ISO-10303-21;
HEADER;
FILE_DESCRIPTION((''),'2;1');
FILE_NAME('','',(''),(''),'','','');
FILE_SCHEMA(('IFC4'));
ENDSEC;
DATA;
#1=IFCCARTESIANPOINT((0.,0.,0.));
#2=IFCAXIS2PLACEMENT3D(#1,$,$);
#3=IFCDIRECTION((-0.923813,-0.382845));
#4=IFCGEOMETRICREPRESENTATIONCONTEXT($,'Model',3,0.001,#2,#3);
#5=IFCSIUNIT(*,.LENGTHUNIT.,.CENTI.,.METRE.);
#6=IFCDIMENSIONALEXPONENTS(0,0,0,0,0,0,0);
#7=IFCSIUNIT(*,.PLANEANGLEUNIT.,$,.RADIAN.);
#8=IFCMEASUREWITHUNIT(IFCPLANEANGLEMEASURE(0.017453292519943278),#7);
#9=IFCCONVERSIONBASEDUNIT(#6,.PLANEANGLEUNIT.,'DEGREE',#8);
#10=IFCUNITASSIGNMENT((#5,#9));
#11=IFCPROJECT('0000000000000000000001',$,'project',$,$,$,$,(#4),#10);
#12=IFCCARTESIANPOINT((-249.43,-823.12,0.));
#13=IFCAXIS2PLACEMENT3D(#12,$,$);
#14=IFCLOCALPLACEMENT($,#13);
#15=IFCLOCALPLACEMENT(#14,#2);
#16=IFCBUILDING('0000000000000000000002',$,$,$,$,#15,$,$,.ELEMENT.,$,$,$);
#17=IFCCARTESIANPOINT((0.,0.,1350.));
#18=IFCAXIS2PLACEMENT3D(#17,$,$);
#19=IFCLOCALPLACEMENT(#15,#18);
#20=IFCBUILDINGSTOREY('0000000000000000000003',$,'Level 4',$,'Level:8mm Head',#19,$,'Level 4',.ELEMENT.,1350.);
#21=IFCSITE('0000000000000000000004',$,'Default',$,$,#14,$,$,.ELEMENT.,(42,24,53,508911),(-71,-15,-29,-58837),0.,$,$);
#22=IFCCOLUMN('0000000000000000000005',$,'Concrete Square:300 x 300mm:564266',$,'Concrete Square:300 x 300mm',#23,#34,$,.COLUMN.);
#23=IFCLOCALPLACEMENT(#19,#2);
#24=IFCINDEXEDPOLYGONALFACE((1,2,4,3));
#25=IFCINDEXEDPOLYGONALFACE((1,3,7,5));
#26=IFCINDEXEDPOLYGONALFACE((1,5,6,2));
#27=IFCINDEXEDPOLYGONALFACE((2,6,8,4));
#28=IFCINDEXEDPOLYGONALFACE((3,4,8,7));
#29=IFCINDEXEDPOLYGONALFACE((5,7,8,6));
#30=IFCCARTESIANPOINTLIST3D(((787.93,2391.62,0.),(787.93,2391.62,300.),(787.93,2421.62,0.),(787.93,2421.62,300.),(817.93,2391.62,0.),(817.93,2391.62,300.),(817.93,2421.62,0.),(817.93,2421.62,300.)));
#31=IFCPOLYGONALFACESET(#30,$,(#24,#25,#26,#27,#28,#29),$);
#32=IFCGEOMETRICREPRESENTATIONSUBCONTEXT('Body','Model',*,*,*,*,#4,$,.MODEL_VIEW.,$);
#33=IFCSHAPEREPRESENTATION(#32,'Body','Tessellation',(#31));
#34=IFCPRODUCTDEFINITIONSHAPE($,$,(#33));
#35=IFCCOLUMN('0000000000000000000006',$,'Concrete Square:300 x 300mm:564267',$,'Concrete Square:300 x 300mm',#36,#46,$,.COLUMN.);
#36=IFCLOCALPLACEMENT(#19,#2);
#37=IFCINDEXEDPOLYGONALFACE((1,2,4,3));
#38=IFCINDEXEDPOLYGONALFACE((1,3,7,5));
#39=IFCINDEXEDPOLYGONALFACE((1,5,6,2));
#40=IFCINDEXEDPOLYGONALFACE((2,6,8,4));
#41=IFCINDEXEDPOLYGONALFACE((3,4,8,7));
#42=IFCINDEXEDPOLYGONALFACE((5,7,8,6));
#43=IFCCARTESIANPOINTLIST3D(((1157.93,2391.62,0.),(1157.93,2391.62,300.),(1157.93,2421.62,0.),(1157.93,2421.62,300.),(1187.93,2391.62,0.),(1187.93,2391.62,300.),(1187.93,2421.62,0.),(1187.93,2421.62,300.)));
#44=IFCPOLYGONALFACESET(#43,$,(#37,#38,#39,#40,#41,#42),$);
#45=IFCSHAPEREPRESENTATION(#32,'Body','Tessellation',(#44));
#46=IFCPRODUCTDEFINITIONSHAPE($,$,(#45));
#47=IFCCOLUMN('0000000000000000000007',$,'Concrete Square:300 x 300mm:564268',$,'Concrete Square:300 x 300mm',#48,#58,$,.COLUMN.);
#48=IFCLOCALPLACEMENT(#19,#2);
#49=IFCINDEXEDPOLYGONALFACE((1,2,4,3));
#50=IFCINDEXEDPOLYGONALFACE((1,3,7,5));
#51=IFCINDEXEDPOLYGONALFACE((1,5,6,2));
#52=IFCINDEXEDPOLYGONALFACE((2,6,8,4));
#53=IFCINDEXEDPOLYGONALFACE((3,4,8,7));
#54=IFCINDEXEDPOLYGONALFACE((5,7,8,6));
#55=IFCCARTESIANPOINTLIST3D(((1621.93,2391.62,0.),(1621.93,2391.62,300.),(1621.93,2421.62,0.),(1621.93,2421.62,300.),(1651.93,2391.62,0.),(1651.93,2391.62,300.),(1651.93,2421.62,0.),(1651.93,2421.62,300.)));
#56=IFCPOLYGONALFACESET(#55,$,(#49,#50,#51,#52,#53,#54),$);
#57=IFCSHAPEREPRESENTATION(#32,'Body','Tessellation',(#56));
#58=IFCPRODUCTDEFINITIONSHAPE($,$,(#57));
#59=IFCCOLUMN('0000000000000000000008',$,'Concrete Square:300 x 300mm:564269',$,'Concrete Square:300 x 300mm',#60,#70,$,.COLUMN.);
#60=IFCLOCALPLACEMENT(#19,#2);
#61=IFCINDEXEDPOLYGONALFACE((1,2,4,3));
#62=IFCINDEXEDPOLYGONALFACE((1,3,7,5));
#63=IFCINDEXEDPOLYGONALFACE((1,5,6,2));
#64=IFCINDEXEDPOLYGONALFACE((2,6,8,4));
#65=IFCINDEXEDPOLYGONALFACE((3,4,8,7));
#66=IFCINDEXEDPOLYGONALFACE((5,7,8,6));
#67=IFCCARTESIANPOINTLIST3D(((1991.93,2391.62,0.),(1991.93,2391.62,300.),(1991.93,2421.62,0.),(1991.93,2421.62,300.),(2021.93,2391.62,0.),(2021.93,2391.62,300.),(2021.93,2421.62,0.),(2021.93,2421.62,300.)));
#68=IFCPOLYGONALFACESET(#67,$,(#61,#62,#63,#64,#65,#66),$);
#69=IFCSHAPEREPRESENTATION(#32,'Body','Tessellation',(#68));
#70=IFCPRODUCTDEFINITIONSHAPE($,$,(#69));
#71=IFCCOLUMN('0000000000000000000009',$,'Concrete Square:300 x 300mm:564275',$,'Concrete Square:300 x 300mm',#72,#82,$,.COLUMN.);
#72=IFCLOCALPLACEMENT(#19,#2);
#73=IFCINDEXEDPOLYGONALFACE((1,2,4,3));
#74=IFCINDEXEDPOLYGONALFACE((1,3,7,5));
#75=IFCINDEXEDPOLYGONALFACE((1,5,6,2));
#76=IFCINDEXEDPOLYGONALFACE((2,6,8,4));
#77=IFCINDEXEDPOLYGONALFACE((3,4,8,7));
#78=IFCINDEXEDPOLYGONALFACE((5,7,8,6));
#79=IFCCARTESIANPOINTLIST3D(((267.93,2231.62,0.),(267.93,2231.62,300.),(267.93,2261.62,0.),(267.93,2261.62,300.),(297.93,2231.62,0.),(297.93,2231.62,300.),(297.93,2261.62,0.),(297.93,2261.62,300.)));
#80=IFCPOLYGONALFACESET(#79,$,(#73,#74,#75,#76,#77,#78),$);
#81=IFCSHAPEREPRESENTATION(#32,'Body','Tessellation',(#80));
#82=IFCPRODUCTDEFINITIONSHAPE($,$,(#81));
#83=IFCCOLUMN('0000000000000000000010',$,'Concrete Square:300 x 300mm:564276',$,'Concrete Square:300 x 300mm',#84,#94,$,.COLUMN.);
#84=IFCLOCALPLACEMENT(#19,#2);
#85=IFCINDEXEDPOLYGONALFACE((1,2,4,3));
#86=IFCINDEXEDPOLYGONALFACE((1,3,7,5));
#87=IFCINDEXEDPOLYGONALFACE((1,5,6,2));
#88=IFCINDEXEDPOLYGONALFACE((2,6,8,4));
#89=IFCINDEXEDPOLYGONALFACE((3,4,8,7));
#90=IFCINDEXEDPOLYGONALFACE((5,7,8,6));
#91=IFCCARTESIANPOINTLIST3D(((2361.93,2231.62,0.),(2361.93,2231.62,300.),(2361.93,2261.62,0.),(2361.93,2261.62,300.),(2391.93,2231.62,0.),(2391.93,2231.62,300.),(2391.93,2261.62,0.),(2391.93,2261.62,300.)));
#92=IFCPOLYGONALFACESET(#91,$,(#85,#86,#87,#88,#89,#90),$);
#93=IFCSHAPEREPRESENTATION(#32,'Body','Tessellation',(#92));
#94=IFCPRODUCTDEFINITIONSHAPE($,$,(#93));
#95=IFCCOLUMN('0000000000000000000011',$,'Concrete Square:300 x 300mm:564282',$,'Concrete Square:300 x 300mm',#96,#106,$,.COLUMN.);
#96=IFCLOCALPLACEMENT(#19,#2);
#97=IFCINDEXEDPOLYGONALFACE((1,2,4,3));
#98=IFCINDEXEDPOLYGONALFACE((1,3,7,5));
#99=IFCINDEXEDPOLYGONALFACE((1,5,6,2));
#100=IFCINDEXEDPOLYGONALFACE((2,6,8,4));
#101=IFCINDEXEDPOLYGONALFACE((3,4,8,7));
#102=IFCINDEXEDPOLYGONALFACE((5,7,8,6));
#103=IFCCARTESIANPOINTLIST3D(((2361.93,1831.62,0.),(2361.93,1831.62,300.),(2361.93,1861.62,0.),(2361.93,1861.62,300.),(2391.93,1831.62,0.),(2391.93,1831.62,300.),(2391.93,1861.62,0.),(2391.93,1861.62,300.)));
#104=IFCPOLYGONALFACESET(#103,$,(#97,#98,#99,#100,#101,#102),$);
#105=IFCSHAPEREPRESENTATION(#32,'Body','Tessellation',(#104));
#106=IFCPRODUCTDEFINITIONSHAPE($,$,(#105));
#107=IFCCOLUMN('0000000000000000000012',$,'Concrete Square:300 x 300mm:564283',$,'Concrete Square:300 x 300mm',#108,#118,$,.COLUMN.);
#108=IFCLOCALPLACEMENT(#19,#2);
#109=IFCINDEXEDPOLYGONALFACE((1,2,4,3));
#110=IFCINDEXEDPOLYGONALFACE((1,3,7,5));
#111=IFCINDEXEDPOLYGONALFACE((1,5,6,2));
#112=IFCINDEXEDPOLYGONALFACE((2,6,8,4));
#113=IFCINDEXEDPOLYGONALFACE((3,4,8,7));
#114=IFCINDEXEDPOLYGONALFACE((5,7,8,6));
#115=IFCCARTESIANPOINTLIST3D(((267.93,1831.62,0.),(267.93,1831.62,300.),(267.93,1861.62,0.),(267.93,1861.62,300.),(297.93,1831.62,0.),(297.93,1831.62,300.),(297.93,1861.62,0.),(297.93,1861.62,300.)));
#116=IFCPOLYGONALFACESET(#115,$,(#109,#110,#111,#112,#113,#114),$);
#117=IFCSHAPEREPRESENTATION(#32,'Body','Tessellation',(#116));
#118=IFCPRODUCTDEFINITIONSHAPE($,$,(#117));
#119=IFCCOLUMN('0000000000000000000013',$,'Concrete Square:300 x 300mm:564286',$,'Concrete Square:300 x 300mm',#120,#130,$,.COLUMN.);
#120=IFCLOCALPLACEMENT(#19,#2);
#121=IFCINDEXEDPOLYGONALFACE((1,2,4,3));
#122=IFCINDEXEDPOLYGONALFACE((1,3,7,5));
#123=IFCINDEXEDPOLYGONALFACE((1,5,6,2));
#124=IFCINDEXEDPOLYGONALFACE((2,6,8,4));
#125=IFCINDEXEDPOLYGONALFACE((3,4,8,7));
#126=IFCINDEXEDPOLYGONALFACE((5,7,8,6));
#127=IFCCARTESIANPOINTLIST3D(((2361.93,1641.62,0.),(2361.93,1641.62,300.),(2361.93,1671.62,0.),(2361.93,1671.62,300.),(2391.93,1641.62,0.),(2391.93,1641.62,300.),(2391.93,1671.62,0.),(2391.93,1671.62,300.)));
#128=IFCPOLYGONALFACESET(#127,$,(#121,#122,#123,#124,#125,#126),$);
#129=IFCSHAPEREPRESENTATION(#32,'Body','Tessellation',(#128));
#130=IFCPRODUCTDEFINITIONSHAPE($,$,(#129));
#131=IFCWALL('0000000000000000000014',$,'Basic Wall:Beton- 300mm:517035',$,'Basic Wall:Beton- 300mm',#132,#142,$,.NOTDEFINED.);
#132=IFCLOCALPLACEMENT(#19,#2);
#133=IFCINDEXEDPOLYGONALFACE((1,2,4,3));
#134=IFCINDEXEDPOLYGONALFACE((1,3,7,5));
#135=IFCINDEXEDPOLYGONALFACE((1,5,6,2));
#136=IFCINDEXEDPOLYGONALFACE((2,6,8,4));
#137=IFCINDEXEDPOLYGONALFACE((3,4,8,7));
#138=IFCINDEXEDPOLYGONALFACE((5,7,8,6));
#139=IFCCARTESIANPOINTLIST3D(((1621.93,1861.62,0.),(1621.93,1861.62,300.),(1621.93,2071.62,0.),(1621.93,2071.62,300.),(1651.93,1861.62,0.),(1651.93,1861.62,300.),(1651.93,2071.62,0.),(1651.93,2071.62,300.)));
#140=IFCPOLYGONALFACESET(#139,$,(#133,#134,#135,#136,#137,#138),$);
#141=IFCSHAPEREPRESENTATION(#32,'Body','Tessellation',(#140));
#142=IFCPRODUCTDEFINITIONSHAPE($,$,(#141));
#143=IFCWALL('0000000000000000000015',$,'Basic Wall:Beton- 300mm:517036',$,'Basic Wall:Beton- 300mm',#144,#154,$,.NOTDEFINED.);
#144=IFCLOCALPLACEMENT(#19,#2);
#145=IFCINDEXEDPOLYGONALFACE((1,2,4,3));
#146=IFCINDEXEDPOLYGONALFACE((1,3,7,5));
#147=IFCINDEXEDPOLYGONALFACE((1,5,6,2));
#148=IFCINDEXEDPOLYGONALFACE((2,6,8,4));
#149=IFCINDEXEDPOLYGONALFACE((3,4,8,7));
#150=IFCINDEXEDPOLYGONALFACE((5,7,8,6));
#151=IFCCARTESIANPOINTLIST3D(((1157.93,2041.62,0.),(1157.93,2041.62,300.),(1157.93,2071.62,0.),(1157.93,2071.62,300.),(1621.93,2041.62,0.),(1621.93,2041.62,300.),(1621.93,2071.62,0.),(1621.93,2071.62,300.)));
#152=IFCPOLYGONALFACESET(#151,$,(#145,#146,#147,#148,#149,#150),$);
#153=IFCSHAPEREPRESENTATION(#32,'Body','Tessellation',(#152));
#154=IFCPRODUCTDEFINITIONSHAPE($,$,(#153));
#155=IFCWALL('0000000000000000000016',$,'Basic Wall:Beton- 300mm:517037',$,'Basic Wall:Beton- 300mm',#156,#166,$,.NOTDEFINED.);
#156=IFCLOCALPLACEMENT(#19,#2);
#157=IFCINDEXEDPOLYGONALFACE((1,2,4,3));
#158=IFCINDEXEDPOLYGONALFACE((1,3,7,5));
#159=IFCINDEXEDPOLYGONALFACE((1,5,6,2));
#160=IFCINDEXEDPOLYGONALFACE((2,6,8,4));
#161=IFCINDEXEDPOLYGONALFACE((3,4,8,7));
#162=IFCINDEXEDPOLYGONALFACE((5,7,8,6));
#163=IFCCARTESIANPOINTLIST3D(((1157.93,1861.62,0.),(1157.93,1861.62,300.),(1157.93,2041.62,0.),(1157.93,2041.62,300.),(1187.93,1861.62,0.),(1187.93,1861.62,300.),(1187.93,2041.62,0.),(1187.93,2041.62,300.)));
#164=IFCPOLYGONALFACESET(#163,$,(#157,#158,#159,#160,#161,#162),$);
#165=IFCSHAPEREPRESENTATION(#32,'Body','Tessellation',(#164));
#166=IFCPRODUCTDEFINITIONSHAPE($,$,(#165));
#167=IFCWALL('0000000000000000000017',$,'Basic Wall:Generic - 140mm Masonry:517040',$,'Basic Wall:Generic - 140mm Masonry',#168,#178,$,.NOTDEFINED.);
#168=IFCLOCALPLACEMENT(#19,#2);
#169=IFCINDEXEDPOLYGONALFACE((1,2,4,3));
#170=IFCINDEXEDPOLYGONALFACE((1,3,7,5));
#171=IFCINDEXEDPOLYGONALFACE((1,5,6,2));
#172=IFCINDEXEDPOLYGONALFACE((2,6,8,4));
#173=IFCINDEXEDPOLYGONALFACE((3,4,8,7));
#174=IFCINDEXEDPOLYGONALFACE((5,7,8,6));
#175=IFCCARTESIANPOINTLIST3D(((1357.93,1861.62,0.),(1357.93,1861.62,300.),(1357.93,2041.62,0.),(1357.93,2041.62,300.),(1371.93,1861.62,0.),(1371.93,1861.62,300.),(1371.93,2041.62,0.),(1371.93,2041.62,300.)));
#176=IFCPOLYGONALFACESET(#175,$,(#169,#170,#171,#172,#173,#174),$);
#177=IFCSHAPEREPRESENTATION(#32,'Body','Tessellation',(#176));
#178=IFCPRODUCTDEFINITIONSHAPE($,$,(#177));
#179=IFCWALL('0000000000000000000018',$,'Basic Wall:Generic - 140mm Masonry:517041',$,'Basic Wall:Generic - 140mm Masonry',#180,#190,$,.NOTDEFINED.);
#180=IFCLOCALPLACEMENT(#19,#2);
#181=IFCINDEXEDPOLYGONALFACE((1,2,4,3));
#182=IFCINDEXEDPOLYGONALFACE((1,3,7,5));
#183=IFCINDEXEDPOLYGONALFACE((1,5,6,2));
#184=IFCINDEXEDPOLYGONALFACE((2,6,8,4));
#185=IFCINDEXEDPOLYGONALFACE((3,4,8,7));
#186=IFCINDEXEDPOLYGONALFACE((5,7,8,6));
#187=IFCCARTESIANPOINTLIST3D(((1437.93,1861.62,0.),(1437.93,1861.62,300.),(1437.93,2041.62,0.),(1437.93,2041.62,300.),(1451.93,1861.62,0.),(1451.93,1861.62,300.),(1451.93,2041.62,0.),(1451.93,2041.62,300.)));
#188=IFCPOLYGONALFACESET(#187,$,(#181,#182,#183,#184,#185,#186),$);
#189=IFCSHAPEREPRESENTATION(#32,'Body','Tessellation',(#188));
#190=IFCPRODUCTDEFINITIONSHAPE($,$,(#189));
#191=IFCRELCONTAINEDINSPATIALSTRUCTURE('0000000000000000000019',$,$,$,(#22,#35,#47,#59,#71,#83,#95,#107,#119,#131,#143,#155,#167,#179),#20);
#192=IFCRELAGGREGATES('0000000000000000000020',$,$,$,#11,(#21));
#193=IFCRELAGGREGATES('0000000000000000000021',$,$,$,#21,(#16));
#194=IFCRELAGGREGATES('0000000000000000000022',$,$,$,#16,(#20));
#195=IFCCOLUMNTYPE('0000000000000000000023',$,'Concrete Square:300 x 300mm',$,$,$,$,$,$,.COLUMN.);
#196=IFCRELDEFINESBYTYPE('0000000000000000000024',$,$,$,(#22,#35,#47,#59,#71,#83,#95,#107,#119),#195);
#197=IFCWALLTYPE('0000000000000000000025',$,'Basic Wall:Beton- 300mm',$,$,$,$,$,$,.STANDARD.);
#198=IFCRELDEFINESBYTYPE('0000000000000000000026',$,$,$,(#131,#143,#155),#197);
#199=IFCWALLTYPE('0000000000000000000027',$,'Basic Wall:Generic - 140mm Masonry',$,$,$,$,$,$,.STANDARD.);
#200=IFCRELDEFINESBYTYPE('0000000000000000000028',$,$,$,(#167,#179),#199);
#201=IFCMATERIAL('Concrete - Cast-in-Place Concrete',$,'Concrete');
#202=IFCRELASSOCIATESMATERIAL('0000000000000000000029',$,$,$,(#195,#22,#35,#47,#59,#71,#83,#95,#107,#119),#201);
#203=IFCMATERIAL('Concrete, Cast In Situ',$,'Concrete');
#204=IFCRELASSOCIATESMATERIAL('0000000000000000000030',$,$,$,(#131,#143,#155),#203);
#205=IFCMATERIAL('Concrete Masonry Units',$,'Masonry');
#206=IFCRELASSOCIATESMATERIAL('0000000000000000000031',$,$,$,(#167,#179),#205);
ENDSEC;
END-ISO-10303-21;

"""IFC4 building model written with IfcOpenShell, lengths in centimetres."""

from ifc_helpers import new_model, entity, si_unit, converted_unit, direction, frame, origin, place, context, subcontext, project, spatial, indexed_curve, outline, extrude, source, transform, mapped, material, type_object, type_shapes, element, save


model = new_model("IFC4")

# Units and contexts
model_context = context("Model", 3, precision=0.001, world=origin(), true_north=direction((-0.923813, -0.382845)))
body_context = subcontext(model_context, "Body", "Model", "MODEL_VIEW")
ifc_project = project(units=[si_unit("LENGTHUNIT", "METRE", prefix="CENTI"), converted_unit("PLANEANGLEUNIT", "DEGREE", entity("IfcPlaneAngleMeasure", 0.017453292519943278), si_unit("PLANEANGLEUNIT", "RADIAN"), dimensions=[0, 0, 0, 0, 0, 0, 0])], contexts=[model_context])

# Site, building, storey
site_placement = place(None, frame((-249.43, -823.12, 0.0)))
site = spatial("IfcSite", under=ifc_project, at=site_placement, Name="Default", CompositionType="ELEMENT", RefLatitude=(42, 24, 53, 508911), RefLongitude=(-71, -15, -29, -58837), RefElevation=0.0)
building_placement = place(site_placement, origin())
building = spatial("IfcBuilding", under=site, at=building_placement, CompositionType="ELEMENT")
storey_placement = place(building_placement, frame((0.0, 0.0, 1350.0)))
storey = spatial("IfcBuildingStorey", under=building, at=storey_placement, Name="Level 4", ObjectType="Level:8mm Head", LongName="Level 4", CompositionType="ELEMENT", Elevation=1350.0)

# Columns
ifc_material_1 = material(Name="Concrete - Cast-in-Place Concrete", Category="Concrete")
column_type = type_object("IfcColumnType", Name="Concrete Square:300 x 300mm", PredefinedType="COLUMN", material=ifc_material_1)
shared_shape_1 = source(origin(), body_context, "Body", "SweptSolid", [
    extrude(outline(indexed_curve([(-15.0, -15.0), (15.0, -15.0), (15.0, 15.0), (-15.0, 15.0), (-15.0, -15.0)], self_intersect=False)), frame((0.0, 0.0, 1350.0), z_axis=(0.0, 0.0, 1.0), x_axis=(-1.0, 0.0, 0.0)), (0.0, 0.0, 1.0), 300.0),
])
type_shapes(column_type, [shared_shape_1])
for number, where, name in (
    (1, (802.93, 2406.62, -1350.0), "Concrete Square:300 x 300mm:564266"),
    (2, (1172.93, 2406.62, -1350.0), "Concrete Square:300 x 300mm:564267"),
    (3, (1636.93, 2406.62, -1350.0), "Concrete Square:300 x 300mm:564268"),
    (4, (2006.93, 2406.62, -1350.0), "Concrete Square:300 x 300mm:564269"),
    (5, (282.93, 2246.62, -1350.0), "Concrete Square:300 x 300mm:564275"),
    (6, (2376.93, 2246.62, -1350.0), "Concrete Square:300 x 300mm:564276"),
    (7, (2376.93, 1846.62, -1350.0), "Concrete Square:300 x 300mm:564282"),
    (8, (282.93, 1846.62, -1350.0), "Concrete Square:300 x 300mm:564283"),
    (9, (2376.93, 1656.62, -1350.0), "Concrete Square:300 x 300mm:564286"),
):
    element("IfcColumn", number, at=place(storey_placement, frame(where)), inside=storey, type_object=column_type, material=ifc_material_1, Name=name, ObjectType="Concrete Square:300 x 300mm", PredefinedType="COLUMN", context=body_context, shape_type="MappedRepresentation", body=[
        mapped(shared_shape_1, transform((0.0, 0.0, 0.0), scale=1.0)),
    ])

# Walls
ifc_material_2 = material(Name="Concrete, Cast In Situ", Category="Concrete")
wall_type_1 = type_object("IfcWallType", Name="Basic Wall:Beton- 300mm", PredefinedType="STANDARD")
wall_1_placement = place(storey_placement, frame((1636.93, 1861.62, 0.0), z_axis=(0.0, 0.0, 1.0), x_axis=(0.0, 1.0, 0.0)))
element("IfcWall", 10, at=wall_1_placement, inside=storey, type_object=wall_type_1, material=ifc_material_2, Name="Basic Wall:Beton- 300mm:517035", ObjectType="Basic Wall:Beton- 300mm", PredefinedType="NOTDEFINED", context=body_context, shape_type="SweptSolid", body=[
    extrude(outline(indexed_curve([(210.0, 15.0), (0.0, 15.0), (0.0, -15.0), (210.0, -15.0), (210.0, 15.0)], self_intersect=False)), origin(), (0.0, 0.0, 1.0), 300.0),
])
wall_2_placement = place(storey_placement, frame((1621.93, 2056.62, 0.0), z_axis=(0.0, 0.0, 1.0), x_axis=(-1.0, 0.0, 0.0)))
element("IfcWall", 11, at=wall_2_placement, inside=storey, type_object=wall_type_1, material=ifc_material_2, Name="Basic Wall:Beton- 300mm:517036", ObjectType="Basic Wall:Beton- 300mm", PredefinedType="NOTDEFINED", context=body_context, shape_type="SweptSolid", body=[
    extrude(outline(indexed_curve([(464.0, 15.0), (0.0, 15.0), (0.0, -15.0), (464.0, -15.0), (464.0, 15.0)], self_intersect=False)), origin(), (0.0, 0.0, 1.0), 300.0),
])
wall_3_placement = place(storey_placement, frame((1172.93, 2041.62, 0.0), z_axis=(0.0, 0.0, 1.0), x_axis=(0.0, -1.0, 0.0)))
element("IfcWall", 12, at=wall_3_placement, inside=storey, type_object=wall_type_1, material=ifc_material_2, Name="Basic Wall:Beton- 300mm:517037", ObjectType="Basic Wall:Beton- 300mm", PredefinedType="NOTDEFINED", context=body_context, shape_type="SweptSolid", body=[
    extrude(outline(indexed_curve([(180.0, 15.0), (0.0, 15.0), (0.0, -15.0), (180.0, -15.0), (180.0, 15.0)], self_intersect=False)), origin(), (0.0, 0.0, 1.0), 300.0),
])
ifc_material_3 = material(Name="Concrete Masonry Units", Category="Masonry")
wall_type_2 = type_object("IfcWallType", Name="Basic Wall:Generic - 140mm Masonry", PredefinedType="STANDARD")
wall_4_placement = place(storey_placement, frame((1364.93, 2041.62, 0.0), z_axis=(0.0, 0.0, 1.0), x_axis=(0.0, -1.0, 0.0)))
element("IfcWall", 13, at=wall_4_placement, inside=storey, type_object=wall_type_2, material=ifc_material_3, Name="Basic Wall:Generic - 140mm Masonry:517040", ObjectType="Basic Wall:Generic - 140mm Masonry", PredefinedType="NOTDEFINED", context=body_context, shape_type="SweptSolid", body=[
    extrude(outline(indexed_curve([(180.0, 7.0), (0.0, 7.0), (0.0, -7.0), (180.0, -7.0), (180.0, 7.0)], self_intersect=False)), origin(), (0.0, 0.0, 1.0), 300.0),
])
wall_5_placement = place(storey_placement, frame((1444.93, 2041.62, 0.0), z_axis=(0.0, 0.0, 1.0), x_axis=(0.0, -1.0, 0.0)))
element("IfcWall", 14, at=wall_5_placement, inside=storey, type_object=wall_type_2, material=ifc_material_3, Name="Basic Wall:Generic - 140mm Masonry:517041", ObjectType="Basic Wall:Generic - 140mm Masonry", PredefinedType="NOTDEFINED", context=body_context, shape_type="SweptSolid", body=[
    extrude(outline(indexed_curve([(180.0, 7.0), (0.0, 7.0), (0.0, -7.0), (180.0, -7.0), (180.0, 7.0)], self_intersect=False)), origin(), (0.0, 0.0, 1.0), 300.0),
])

save(model, "model.ifc")
